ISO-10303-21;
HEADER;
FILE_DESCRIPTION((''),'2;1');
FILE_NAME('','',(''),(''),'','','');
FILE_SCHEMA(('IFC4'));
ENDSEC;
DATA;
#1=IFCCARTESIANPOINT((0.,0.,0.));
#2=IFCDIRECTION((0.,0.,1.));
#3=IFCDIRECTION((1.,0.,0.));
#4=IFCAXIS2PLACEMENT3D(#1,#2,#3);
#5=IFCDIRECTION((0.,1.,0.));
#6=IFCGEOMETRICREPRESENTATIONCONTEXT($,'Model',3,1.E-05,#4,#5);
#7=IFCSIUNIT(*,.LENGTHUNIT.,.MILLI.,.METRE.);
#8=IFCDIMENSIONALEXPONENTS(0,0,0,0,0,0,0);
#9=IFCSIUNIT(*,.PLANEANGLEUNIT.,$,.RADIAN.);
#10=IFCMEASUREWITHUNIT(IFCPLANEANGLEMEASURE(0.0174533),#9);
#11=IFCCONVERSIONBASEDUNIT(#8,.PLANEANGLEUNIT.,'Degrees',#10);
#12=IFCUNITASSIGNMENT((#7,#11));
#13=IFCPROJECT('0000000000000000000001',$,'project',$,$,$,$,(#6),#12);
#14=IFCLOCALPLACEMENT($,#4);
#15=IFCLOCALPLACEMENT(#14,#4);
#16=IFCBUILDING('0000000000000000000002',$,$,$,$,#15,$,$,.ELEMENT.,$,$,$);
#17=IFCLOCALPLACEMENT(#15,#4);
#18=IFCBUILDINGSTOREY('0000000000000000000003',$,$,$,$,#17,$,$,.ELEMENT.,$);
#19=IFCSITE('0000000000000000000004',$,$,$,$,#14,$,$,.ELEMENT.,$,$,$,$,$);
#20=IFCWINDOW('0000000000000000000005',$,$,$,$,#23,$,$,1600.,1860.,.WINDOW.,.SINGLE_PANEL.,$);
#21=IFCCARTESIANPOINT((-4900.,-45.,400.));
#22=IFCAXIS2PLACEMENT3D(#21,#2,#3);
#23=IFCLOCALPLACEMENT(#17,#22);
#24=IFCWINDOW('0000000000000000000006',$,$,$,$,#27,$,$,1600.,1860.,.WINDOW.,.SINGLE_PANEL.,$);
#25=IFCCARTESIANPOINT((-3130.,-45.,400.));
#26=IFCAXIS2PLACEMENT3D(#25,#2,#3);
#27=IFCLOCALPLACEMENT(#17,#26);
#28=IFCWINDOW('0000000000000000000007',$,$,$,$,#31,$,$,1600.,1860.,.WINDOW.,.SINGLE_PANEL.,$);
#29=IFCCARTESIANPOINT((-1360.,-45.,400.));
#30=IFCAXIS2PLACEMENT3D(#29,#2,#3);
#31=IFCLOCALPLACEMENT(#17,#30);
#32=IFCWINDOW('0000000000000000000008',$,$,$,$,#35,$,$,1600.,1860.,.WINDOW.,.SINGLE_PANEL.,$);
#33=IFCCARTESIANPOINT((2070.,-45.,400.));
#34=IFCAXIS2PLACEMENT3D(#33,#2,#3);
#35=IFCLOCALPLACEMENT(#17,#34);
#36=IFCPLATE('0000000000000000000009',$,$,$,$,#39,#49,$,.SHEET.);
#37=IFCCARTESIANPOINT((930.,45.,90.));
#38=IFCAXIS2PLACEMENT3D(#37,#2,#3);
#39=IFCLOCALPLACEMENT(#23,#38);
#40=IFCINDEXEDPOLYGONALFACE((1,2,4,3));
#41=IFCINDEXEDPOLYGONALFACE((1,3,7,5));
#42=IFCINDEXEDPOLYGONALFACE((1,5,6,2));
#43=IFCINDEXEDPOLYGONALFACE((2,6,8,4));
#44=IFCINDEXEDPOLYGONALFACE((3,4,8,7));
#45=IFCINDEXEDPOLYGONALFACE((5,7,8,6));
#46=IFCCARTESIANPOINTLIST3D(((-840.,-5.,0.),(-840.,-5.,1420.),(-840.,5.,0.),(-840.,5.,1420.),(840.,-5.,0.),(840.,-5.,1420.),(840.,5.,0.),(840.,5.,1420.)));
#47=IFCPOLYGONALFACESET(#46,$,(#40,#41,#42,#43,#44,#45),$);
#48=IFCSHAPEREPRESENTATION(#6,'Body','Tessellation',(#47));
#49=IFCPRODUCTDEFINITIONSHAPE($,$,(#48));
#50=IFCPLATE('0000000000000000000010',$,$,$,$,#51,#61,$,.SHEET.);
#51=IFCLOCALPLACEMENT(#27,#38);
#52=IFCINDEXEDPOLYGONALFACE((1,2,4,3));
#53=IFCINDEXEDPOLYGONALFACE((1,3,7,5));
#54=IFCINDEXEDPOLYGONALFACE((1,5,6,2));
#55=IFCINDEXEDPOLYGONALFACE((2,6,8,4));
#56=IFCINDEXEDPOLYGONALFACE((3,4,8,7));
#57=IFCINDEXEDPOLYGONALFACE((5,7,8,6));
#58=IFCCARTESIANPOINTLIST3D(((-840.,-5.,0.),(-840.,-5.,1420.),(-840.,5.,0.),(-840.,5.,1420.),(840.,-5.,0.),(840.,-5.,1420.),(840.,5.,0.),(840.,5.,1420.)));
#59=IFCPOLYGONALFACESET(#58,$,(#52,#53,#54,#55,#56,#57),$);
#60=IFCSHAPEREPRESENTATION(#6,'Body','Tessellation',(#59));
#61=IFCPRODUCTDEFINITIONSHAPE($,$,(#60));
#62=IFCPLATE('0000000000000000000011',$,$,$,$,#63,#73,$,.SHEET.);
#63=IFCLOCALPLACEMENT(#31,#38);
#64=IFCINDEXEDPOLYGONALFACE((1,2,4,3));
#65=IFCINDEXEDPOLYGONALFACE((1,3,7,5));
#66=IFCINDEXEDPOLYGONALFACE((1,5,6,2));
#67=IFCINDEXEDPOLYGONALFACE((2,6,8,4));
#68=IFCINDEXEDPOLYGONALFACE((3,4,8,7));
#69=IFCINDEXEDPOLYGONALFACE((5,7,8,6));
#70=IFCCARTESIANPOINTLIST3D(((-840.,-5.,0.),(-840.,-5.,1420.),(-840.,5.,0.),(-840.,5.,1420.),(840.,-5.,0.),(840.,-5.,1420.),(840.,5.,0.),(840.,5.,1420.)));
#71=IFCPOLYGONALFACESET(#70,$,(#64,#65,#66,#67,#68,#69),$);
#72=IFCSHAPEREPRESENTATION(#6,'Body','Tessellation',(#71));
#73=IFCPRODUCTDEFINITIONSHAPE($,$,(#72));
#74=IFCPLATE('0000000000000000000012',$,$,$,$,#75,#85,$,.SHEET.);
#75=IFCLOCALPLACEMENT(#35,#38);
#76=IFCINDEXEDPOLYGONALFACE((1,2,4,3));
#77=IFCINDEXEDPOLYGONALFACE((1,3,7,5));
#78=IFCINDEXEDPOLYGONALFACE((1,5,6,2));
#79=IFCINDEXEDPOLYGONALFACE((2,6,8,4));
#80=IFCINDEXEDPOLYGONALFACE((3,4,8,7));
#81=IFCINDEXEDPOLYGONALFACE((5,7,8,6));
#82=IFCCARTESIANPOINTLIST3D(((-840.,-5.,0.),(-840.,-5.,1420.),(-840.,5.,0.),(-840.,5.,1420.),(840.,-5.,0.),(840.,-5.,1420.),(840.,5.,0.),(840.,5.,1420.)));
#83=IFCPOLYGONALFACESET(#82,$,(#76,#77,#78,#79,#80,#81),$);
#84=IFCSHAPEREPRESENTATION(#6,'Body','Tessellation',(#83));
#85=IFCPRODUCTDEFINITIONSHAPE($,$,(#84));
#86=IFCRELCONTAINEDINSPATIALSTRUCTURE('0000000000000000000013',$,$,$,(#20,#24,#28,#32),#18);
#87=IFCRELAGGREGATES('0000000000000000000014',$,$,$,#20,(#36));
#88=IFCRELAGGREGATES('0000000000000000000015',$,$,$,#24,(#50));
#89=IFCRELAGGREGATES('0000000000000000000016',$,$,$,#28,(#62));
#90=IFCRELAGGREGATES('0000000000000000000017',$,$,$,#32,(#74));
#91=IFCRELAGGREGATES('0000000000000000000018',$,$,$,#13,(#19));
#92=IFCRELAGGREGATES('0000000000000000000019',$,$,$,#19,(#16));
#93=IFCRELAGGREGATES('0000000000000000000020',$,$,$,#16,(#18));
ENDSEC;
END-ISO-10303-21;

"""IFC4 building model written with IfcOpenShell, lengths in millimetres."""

from ifc_helpers import new_model, entity, si_unit, converted_unit, direction, frame, origin_with_axes, place, context, project, spatial, polyline, outline, extrude, element, aggregate, save


model = new_model("IFC4")

# Units and contexts
model_context = context("Model", 3, precision=1e-05, world=origin_with_axes(), true_north=direction((0.0, 1.0, 0.0)))
ifc_project = project(units=[si_unit("LENGTHUNIT", "METRE", prefix="MILLI"), converted_unit("PLANEANGLEUNIT", "Degrees", entity("IfcPlaneAngleMeasure", 0.0174533), si_unit("PLANEANGLEUNIT", "RADIAN"), dimensions=[0, 0, 0, 0, 0, 0, 0])], contexts=[model_context])

# Site, building, storey
site_placement = place(None, origin_with_axes())
site = spatial("IfcSite", under=ifc_project, at=site_placement, CompositionType="ELEMENT")
building_placement = place(site_placement, origin_with_axes())
building = spatial("IfcBuilding", under=site, at=building_placement, CompositionType="ELEMENT")
storey_placement = place(building_placement, origin_with_axes())
storey = spatial("IfcBuildingStorey", under=building, at=storey_placement, CompositionType="ELEMENT")

# Windows
window_1_placement = place(storey_placement, frame((-4900.0, -45.0, 400.0), z_axis=(0.0, 0.0, 1.0), x_axis=(1.0, 0.0, 0.0)))
window_1 = element("IfcWindow", 1, at=window_1_placement, inside=storey, OverallHeight=1600.0, OverallWidth=1860.0, PartitioningType="SINGLE_PANEL", PredefinedType="WINDOW")
window_2_placement = place(storey_placement, frame((-3130.0, -45.0, 400.0), z_axis=(0.0, 0.0, 1.0), x_axis=(1.0, 0.0, 0.0)))
window_2 = element("IfcWindow", 2, at=window_2_placement, inside=storey, OverallHeight=1600.0, OverallWidth=1860.0, PartitioningType="SINGLE_PANEL", PredefinedType="WINDOW")
window_3_placement = place(storey_placement, frame((-1360.0, -45.0, 400.0), z_axis=(0.0, 0.0, 1.0), x_axis=(1.0, 0.0, 0.0)))
window_3 = element("IfcWindow", 3, at=window_3_placement, inside=storey, OverallHeight=1600.0, OverallWidth=1860.0, PartitioningType="SINGLE_PANEL", PredefinedType="WINDOW")
window_4_placement = place(storey_placement, frame((2070.0, -45.0, 400.0), z_axis=(0.0, 0.0, 1.0), x_axis=(1.0, 0.0, 0.0)))
window_4 = element("IfcWindow", 4, at=window_4_placement, inside=storey, OverallHeight=1600.0, OverallWidth=1860.0, PartitioningType="SINGLE_PANEL", PredefinedType="WINDOW")

# Plates
plate_1_placement = place(window_1_placement, frame((930.0, 45.0, 90.0), z_axis=(0.0, 0.0, 1.0), x_axis=(1.0, 0.0, 0.0)))
plate_1 = element("IfcPlate", 5, at=plate_1_placement, PredefinedType="SHEET", context=model_context, shape_type="SweptSolid", body=[
    extrude(outline(polyline([(-840.0, -5.0), (840.0, -5.0), (840.0, 5.0), (-840.0, 5.0), (-840.0, -5.0), (-840.0, -5.0)])), origin_with_axes(), (0.0, 0.0, 1.0), 1420.0),
])
aggregate(window_1, [plate_1])
plate_2_placement = place(window_2_placement, frame((930.0, 45.0, 90.0), z_axis=(0.0, 0.0, 1.0), x_axis=(1.0, 0.0, 0.0)))
plate_2 = element("IfcPlate", 6, at=plate_2_placement, PredefinedType="SHEET", context=model_context, shape_type="SweptSolid", body=[
    extrude(outline(polyline([(-840.0, -5.0), (840.0, -5.0), (840.0, 5.0), (-840.0, 5.0), (-840.0, -5.0), (-840.0, -5.0)])), origin_with_axes(), (0.0, 0.0, 1.0), 1420.0),
])
aggregate(window_2, [plate_2])
plate_3_placement = place(window_3_placement, frame((930.0, 45.0, 90.0), z_axis=(0.0, 0.0, 1.0), x_axis=(1.0, 0.0, 0.0)))
plate_3 = element("IfcPlate", 7, at=plate_3_placement, PredefinedType="SHEET", context=model_context, shape_type="SweptSolid", body=[
    extrude(outline(polyline([(-840.0, -5.0), (840.0, -5.0), (840.0, 5.0), (-840.0, 5.0), (-840.0, -5.0), (-840.0, -5.0)])), origin_with_axes(), (0.0, 0.0, 1.0), 1420.0),
])
aggregate(window_3, [plate_3])
plate_4_placement = place(window_4_placement, frame((930.0, 45.0, 90.0), z_axis=(0.0, 0.0, 1.0), x_axis=(1.0, 0.0, 0.0)))
plate_4 = element("IfcPlate", 8, at=plate_4_placement, PredefinedType="SHEET", context=model_context, shape_type="SweptSolid", body=[
    extrude(outline(polyline([(-840.0, -5.0), (840.0, -5.0), (840.0, 5.0), (-840.0, 5.0), (-840.0, -5.0), (-840.0, -5.0)])), origin_with_axes(), (0.0, 0.0, 1.0), 1420.0),
])
aggregate(window_4, [plate_4])

save(model, "model.ifc")
